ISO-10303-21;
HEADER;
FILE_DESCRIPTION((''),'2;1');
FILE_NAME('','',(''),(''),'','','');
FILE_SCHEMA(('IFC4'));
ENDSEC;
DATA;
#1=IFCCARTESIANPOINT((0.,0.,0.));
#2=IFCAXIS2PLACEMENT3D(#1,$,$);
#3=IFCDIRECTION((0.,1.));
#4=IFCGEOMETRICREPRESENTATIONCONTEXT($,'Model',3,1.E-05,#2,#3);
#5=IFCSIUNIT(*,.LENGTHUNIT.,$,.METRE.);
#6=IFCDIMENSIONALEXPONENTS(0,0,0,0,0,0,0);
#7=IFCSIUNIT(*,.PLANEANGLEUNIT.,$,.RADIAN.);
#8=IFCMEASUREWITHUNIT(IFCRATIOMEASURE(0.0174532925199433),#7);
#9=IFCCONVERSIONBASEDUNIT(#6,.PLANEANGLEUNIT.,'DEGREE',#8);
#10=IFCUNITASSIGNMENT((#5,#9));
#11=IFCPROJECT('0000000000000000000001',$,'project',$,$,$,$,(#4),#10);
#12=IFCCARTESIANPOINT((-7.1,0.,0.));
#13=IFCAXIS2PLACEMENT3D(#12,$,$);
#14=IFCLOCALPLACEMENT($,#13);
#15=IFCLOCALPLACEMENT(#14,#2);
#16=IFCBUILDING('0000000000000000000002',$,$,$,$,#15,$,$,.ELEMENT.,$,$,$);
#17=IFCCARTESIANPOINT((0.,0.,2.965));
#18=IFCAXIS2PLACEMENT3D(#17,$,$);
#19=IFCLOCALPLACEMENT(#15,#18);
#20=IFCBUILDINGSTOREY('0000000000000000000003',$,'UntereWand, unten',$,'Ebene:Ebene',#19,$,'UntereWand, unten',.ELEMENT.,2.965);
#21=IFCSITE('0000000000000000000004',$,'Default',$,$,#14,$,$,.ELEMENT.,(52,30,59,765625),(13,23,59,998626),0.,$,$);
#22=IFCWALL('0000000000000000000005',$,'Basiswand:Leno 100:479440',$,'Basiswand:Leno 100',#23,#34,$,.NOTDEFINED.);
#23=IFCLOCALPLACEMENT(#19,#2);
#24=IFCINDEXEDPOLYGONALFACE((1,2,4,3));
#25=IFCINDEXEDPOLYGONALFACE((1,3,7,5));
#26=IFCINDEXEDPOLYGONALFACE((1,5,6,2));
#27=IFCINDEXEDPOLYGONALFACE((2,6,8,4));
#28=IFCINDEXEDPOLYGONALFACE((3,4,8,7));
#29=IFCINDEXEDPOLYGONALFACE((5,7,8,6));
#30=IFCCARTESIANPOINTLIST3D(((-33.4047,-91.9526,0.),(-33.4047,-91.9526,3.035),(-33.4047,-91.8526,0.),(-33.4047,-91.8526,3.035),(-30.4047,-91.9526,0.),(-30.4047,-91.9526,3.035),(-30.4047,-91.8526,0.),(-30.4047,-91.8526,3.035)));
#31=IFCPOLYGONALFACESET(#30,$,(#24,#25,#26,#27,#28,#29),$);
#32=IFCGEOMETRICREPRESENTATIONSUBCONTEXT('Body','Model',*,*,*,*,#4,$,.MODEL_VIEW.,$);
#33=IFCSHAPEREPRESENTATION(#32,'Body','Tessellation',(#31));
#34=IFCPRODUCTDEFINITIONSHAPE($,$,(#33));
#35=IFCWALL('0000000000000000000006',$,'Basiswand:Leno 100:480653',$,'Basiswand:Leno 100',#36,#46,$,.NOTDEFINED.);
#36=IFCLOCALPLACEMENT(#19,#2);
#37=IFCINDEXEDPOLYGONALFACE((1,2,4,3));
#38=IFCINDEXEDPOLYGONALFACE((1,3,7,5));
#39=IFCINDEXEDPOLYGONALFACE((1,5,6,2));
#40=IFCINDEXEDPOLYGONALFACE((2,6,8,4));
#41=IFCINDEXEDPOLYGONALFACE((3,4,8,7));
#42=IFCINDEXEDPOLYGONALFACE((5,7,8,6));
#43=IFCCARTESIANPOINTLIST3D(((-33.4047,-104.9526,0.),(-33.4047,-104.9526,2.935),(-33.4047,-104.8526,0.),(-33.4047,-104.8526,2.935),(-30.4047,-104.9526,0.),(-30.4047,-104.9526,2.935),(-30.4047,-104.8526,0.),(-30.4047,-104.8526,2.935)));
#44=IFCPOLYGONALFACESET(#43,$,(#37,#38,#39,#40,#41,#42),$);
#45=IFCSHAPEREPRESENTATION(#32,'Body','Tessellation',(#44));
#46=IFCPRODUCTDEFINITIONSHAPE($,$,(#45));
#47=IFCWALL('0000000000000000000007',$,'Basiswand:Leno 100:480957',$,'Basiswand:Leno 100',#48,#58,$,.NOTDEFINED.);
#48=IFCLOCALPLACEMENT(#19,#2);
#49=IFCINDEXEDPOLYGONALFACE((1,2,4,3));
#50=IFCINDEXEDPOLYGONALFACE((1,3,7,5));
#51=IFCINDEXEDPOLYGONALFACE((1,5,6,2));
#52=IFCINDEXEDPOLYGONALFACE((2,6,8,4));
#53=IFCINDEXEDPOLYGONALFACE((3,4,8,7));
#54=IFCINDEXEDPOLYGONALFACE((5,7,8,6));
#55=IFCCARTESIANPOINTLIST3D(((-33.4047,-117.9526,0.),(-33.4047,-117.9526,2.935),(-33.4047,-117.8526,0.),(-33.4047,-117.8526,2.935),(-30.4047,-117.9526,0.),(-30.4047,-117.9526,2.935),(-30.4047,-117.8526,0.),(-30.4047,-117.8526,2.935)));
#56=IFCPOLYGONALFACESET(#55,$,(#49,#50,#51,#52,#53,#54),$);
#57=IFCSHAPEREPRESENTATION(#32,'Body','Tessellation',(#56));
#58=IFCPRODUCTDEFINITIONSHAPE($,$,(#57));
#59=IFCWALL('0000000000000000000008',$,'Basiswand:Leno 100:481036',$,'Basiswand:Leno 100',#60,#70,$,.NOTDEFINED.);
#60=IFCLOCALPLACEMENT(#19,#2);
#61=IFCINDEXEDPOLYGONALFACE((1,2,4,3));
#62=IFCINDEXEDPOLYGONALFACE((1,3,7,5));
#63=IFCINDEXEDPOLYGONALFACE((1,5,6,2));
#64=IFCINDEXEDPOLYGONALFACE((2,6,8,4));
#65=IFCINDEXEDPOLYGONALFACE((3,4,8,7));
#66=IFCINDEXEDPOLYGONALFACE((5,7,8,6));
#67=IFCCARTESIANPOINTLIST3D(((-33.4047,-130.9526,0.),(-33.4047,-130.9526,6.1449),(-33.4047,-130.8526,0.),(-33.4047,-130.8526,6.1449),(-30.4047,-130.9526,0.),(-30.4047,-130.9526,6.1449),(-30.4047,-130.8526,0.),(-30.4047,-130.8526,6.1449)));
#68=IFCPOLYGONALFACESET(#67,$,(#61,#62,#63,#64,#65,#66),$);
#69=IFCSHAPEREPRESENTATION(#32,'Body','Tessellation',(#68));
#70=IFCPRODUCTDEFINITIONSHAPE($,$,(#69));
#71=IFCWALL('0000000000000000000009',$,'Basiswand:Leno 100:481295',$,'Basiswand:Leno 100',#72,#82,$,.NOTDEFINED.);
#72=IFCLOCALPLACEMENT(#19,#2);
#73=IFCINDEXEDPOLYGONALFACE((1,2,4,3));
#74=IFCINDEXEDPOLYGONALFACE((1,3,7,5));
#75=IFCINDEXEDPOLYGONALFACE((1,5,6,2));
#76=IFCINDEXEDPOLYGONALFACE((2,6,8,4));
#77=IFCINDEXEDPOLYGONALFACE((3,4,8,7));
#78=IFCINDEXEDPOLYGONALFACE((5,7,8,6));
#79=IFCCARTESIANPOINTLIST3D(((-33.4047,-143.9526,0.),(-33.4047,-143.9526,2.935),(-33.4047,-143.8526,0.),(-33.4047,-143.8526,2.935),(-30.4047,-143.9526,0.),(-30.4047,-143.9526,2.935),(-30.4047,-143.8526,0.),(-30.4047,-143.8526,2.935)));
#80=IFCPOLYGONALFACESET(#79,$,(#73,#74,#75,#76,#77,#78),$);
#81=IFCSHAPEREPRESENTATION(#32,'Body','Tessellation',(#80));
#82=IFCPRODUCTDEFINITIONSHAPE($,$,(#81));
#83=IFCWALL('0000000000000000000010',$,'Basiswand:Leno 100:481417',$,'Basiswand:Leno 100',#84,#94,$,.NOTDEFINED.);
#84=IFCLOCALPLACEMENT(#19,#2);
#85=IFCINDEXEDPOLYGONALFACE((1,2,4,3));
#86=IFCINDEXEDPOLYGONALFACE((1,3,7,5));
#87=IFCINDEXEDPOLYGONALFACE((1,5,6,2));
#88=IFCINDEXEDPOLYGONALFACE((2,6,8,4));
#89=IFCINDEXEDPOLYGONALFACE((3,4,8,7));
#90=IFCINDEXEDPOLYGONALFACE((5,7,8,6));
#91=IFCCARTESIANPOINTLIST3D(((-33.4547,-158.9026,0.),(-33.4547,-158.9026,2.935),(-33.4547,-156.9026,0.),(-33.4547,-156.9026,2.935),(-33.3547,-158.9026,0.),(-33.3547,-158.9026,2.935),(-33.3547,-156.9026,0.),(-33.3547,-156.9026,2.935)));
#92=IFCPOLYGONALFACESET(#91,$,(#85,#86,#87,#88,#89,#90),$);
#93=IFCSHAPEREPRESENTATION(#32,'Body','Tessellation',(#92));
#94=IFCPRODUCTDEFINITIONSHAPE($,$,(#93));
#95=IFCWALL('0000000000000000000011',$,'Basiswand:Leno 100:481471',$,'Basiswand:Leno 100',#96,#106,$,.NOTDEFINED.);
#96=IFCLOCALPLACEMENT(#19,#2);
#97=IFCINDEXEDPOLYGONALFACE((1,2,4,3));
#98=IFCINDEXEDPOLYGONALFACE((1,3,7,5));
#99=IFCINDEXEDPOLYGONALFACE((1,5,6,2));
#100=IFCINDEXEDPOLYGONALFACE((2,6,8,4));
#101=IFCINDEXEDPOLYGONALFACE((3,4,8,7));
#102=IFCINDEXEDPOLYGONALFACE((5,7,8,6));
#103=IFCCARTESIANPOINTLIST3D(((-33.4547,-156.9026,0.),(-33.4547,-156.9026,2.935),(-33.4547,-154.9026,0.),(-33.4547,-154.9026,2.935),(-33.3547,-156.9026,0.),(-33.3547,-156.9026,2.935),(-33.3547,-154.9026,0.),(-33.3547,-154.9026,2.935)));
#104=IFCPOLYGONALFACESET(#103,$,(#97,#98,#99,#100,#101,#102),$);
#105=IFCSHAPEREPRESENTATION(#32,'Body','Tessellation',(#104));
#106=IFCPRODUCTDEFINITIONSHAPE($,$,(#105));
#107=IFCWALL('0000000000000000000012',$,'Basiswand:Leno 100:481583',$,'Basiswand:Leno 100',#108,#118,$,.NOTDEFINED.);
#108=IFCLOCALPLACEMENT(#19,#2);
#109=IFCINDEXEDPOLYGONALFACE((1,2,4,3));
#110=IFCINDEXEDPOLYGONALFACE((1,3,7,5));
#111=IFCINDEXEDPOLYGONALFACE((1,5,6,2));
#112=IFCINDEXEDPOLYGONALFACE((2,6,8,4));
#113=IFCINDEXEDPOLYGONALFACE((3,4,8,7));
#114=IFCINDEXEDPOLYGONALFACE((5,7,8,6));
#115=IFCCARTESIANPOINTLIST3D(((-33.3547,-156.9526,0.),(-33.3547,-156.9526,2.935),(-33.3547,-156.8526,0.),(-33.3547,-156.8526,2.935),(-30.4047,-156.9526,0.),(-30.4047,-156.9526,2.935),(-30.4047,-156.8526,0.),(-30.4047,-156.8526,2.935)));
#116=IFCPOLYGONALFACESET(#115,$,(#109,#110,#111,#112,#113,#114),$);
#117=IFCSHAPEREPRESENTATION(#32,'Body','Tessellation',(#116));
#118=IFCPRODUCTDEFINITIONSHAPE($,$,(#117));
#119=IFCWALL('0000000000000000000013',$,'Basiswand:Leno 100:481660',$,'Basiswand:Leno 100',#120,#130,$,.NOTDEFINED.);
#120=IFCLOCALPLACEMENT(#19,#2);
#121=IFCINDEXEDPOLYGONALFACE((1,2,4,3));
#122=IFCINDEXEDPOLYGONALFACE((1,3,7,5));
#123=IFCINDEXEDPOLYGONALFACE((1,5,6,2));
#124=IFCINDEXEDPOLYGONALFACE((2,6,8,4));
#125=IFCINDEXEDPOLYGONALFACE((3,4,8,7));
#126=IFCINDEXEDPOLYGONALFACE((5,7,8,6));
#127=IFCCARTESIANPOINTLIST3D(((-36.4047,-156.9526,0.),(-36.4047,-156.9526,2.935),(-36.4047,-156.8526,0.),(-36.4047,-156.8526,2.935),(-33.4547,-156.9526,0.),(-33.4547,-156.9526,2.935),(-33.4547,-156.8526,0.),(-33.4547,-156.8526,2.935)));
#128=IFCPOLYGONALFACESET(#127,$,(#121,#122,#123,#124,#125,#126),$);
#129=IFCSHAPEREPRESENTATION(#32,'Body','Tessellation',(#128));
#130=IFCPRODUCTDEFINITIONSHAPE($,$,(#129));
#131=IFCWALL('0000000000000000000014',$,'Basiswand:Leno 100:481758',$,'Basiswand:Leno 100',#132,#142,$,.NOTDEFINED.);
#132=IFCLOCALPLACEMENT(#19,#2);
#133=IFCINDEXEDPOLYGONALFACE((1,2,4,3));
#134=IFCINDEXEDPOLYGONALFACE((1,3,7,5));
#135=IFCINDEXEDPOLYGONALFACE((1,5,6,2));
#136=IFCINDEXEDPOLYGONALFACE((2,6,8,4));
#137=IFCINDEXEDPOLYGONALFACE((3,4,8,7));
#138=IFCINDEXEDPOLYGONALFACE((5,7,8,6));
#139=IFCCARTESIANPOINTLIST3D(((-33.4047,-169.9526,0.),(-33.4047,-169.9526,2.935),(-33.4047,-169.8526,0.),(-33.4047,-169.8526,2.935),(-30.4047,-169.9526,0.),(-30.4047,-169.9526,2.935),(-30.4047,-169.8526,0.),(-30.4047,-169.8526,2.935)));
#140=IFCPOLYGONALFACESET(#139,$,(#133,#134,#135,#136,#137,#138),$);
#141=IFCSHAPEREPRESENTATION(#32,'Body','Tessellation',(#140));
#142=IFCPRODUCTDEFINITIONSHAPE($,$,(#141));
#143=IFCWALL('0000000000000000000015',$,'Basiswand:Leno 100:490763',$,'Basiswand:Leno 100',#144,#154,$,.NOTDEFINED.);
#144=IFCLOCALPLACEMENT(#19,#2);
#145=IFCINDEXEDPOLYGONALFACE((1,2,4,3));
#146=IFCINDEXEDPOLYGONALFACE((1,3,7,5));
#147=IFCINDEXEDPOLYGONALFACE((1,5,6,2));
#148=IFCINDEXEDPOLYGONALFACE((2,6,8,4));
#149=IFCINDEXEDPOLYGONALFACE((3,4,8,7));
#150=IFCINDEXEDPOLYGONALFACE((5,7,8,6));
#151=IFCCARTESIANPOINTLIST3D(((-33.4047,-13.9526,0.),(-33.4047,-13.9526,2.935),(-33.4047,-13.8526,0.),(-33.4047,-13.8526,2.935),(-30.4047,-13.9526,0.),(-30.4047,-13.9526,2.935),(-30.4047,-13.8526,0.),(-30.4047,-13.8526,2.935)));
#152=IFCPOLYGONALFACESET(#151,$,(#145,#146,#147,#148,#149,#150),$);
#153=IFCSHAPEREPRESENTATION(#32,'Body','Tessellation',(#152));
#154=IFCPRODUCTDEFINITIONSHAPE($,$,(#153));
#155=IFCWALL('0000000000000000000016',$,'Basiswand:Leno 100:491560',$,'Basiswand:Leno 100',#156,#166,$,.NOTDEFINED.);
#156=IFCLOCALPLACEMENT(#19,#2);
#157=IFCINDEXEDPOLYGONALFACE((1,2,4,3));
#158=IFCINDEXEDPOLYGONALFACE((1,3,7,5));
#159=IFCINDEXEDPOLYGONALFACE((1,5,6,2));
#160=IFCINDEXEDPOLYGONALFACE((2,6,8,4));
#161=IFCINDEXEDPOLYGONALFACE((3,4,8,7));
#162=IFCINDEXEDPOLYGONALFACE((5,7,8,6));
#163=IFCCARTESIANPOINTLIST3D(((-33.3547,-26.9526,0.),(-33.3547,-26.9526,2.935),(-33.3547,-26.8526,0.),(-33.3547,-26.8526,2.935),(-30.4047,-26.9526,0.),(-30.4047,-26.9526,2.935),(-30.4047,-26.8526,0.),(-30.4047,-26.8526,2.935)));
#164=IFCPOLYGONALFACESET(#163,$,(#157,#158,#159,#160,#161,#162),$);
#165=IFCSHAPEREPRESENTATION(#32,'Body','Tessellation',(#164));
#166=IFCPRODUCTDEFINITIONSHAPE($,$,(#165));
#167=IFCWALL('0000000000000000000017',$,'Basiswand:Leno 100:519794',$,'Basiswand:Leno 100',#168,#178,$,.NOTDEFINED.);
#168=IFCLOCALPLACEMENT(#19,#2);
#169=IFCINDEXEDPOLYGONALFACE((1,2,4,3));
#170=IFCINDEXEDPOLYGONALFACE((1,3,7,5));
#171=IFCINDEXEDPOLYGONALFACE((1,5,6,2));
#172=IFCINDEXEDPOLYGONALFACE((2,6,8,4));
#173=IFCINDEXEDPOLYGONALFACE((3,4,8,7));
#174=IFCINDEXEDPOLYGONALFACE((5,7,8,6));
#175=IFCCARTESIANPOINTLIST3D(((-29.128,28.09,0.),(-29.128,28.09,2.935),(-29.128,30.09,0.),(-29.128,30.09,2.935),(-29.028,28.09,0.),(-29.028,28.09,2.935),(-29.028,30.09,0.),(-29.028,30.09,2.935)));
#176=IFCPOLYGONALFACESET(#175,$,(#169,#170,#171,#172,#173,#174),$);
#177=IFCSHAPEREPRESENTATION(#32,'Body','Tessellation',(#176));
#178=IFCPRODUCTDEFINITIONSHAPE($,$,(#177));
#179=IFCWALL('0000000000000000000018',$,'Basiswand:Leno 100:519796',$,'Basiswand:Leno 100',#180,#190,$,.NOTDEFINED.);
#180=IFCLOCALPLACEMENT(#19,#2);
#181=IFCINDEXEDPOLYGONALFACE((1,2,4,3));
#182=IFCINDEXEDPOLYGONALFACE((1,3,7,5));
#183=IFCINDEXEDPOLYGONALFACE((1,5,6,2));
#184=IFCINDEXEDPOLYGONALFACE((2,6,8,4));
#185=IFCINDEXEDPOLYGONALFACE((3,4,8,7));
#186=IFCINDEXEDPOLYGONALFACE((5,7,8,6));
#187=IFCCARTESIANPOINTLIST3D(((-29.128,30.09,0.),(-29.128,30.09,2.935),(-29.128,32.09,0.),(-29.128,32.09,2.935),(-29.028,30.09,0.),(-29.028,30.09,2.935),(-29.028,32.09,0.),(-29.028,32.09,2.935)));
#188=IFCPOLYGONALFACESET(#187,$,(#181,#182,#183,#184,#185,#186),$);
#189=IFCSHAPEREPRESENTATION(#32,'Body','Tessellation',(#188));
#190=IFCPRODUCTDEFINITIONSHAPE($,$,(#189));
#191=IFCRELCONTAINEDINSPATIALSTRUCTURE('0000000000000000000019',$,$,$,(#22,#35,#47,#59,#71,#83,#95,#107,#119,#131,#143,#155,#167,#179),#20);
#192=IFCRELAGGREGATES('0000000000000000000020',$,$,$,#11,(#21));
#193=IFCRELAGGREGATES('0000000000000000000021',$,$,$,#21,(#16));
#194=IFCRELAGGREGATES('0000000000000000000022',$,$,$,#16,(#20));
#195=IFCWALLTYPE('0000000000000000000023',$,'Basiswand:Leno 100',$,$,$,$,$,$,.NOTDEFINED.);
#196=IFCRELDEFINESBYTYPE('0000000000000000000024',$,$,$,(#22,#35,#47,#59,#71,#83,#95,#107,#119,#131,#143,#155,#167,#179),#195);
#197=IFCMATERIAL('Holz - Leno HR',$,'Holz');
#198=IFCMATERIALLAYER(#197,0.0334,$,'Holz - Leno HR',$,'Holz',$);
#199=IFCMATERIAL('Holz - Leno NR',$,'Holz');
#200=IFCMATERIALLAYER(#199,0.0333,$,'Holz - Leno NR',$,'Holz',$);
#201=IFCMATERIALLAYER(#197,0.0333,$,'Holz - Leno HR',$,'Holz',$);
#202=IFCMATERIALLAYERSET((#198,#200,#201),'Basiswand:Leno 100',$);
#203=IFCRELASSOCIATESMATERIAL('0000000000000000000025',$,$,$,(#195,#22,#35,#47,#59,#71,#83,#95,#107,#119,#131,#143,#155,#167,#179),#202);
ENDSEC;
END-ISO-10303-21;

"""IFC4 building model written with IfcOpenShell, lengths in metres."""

from ifc_helpers import new_model, entity, si_unit, converted_unit, direction, frame, origin, place, context, subcontext, project, spatial, indexed_curve, outline, extrude, material, layer, layer_set, type_object, element, save


model = new_model("IFC4")

# Units and contexts
model_context = context("Model", 3, precision=1e-05, world=origin(), true_north=direction((0.0, 1.0)))
body_context = subcontext(model_context, "Body", "Model", "MODEL_VIEW")
ifc_project = project(units=[si_unit("LENGTHUNIT", "METRE"), converted_unit("PLANEANGLEUNIT", "DEGREE", entity("IfcRatioMeasure", 0.0174532925199433), si_unit("PLANEANGLEUNIT", "RADIAN"), dimensions=[0, 0, 0, 0, 0, 0, 0])], contexts=[model_context])

# Site, building, storey
site_placement = place(None, frame((-7.1, 0.0, 0.0)))
site = spatial("IfcSite", under=ifc_project, at=site_placement, Name="Default", CompositionType="ELEMENT", RefLatitude=(52, 30, 59, 765625), RefLongitude=(13, 23, 59, 998626), RefElevation=0.0)
building_placement = place(site_placement, origin())
building = spatial("IfcBuilding", under=site, at=building_placement, CompositionType="ELEMENT")
storey_placement = place(building_placement, frame((0.0, 0.0, 2.965)))
storey = spatial("IfcBuildingStorey", under=building, at=storey_placement, Name="UntereWand, unten", ObjectType="Ebene:Ebene", LongName="UntereWand, unten", CompositionType="ELEMENT", Elevation=2.965)

# Walls
ifc_material_1 = material(Name="Holz - Leno HR", Category="Holz")
ifc_layer_1 = layer(ifc_material_1, 0.0334, Name="Holz - Leno HR", Category="Holz")
ifc_material_2 = material(Name="Holz - Leno NR", Category="Holz")
ifc_layer_2 = layer(ifc_material_2, 0.0333, Name="Holz - Leno NR", Category="Holz")
ifc_layer_3 = layer(ifc_material_1, 0.0333, Name="Holz - Leno HR", Category="Holz")
ifc_layer_set = layer_set([ifc_layer_1, ifc_layer_2, ifc_layer_3], Name="Basiswand:Leno 100")
wall_type = type_object("IfcWallType", Name="Basiswand:Leno 100", PredefinedType="NOTDEFINED", material=ifc_layer_set)
wall_1_placement = place(storey_placement, frame((-30.4047, -91.9026, 0.0), z_axis=(0.0, 0.0, 1.0), x_axis=(-1.0, 0.0, 0.0)))
element("IfcWall", 1, at=wall_1_placement, inside=storey, type_object=wall_type, material=ifc_layer_set, Name="Basiswand:Leno 100:479440", ObjectType="Basiswand:Leno 100", PredefinedType="NOTDEFINED", context=body_context, shape_type="SweptSolid", body=[
    extrude(outline(indexed_curve([(3.0, 0.05), (0.0, 0.05), (0.0, -0.05), (3.0, -0.05), (3.0, 0.05)], self_intersect=False)), origin(), (0.0, 0.0, 1.0), 3.035),
])
for number, where, z_axis, x_axis, name in (
    (2, (-30.4047, -104.9026, 0.0), (0.0, 0.0, 1.0), (-1.0, 0.0, 0.0), "Basiswand:Leno 100:480653"),
    (3, (-30.4047, -117.9026, 0.0), (0.0, 0.0, 1.0), (-1.0, 0.0, 0.0), "Basiswand:Leno 100:480957"),
):
    element("IfcWall", number, at=place(storey_placement, frame(where, z_axis=z_axis, x_axis=x_axis)), inside=storey, type_object=wall_type, material=ifc_layer_set, Name=name, ObjectType="Basiswand:Leno 100", PredefinedType="NOTDEFINED", context=body_context, shape_type="SweptSolid", body=[
        extrude(outline(indexed_curve([(3.0, 0.05), (0.0, 0.05), (0.0, -0.05), (3.0, -0.05), (3.0, 0.05)], self_intersect=False)), origin(), (0.0, 0.0, 1.0), 2.935),
    ])
wall_2_placement = place(storey_placement, frame((-30.4047, -130.9026, 0.0), z_axis=(0.0, 0.0, 1.0), x_axis=(-1.0, 0.0, 0.0)))
element("IfcWall", 4, at=wall_2_placement, inside=storey, type_object=wall_type, material=ifc_layer_set, Name="Basiswand:Leno 100:481036", ObjectType="Basiswand:Leno 100", PredefinedType="NOTDEFINED", context=body_context, shape_type="SweptSolid", body=[
    extrude(outline(indexed_curve([(3.0, 0.05), (0.0, 0.05), (0.0, -0.05), (3.0, -0.05), (3.0, 0.05)], self_intersect=False)), origin(), (0.0, 0.0, 1.0), 6.1449),
])
wall_3_placement = place(storey_placement, frame((-30.4047, -143.9026, 0.0), z_axis=(0.0, 0.0, 1.0), x_axis=(-1.0, 0.0, 0.0)))
element("IfcWall", 5, at=wall_3_placement, inside=storey, type_object=wall_type, material=ifc_layer_set, Name="Basiswand:Leno 100:481295", ObjectType="Basiswand:Leno 100", PredefinedType="NOTDEFINED", context=body_context, shape_type="SweptSolid", body=[
    extrude(outline(indexed_curve([(3.0, 0.05), (0.0, 0.05), (0.0, -0.05), (3.0, -0.05), (3.0, 0.05)], self_intersect=False)), origin(), (0.0, 0.0, 1.0), 2.935),
])
wall_4_placement = place(storey_placement, frame((-33.4047, -158.9026, 0.0), z_axis=(0.0, 0.0, 1.0), x_axis=(0.0, 1.0, 0.0)))
element("IfcWall", 6, at=wall_4_placement, inside=storey, type_object=wall_type, material=ifc_layer_set, Name="Basiswand:Leno 100:481417", ObjectType="Basiswand:Leno 100", PredefinedType="NOTDEFINED", context=body_context, shape_type="SweptSolid", body=[
    extrude(outline(indexed_curve([(2.0, 0.05), (0.0, 0.05), (0.0, -0.05), (2.0, -0.05), (2.0, 0.05)], self_intersect=False)), origin(), (0.0, 0.0, 1.0), 2.935),
])
wall_5_placement = place(storey_placement, frame((-33.4047, -154.9026, 0.0), z_axis=(0.0, 0.0, 1.0), x_axis=(0.0, -1.0, 0.0)))
element("IfcWall", 7, at=wall_5_placement, inside=storey, type_object=wall_type, material=ifc_layer_set, Name="Basiswand:Leno 100:481471", ObjectType="Basiswand:Leno 100", PredefinedType="NOTDEFINED", context=body_context, shape_type="SweptSolid", body=[
    extrude(outline(indexed_curve([(2.0, 0.05), (0.0, 0.05), (0.0, -0.05), (2.0, -0.05), (2.0, 0.05)], self_intersect=False)), origin(), (0.0, 0.0, 1.0), 2.935),
])
wall_6_placement = place(storey_placement, frame((-30.4047, -156.9026, 0.0), z_axis=(0.0, 0.0, 1.0), x_axis=(-1.0, 0.0, 0.0)))
element("IfcWall", 8, at=wall_6_placement, inside=storey, type_object=wall_type, material=ifc_layer_set, Name="Basiswand:Leno 100:481583", ObjectType="Basiswand:Leno 100", PredefinedType="NOTDEFINED", context=body_context, shape_type="SweptSolid", body=[
    extrude(outline(indexed_curve([(2.95, 0.05), (0.0, 0.05), (0.0, -0.05), (2.95, -0.05), (2.95, 0.05)], self_intersect=False)), origin(), (0.0, 0.0, 1.0), 2.935),
])
wall_7_placement = place(storey_placement, frame((-36.4047, -156.9026, 0.0)))
element("IfcWall", 9, at=wall_7_placement, inside=storey, type_object=wall_type, material=ifc_layer_set, Name="Basiswand:Leno 100:481660", ObjectType="Basiswand:Leno 100", PredefinedType="NOTDEFINED", context=body_context, shape_type="SweptSolid", body=[
    extrude(outline(indexed_curve([(2.95, 0.05), (0.0, 0.05), (0.0, -0.05), (2.95, -0.05), (2.95, 0.05)], self_intersect=False)), origin(), (0.0, 0.0, 1.0), 2.935),
])
wall_8_placement = place(storey_placement, frame((-30.4047, -169.9026, 0.0), z_axis=(0.0, 0.0, 1.0), x_axis=(-1.0, 0.0, 0.0)))
element("IfcWall", 10, at=wall_8_placement, inside=storey, type_object=wall_type, material=ifc_layer_set, Name="Basiswand:Leno 100:481758", ObjectType="Basiswand:Leno 100", PredefinedType="NOTDEFINED", context=body_context, shape_type="SweptSolid", body=[
    extrude(outline(indexed_curve([(3.0, 0.05), (0.0, 0.05), (0.0, -0.05), (3.0, -0.05), (3.0, 0.05)], self_intersect=False)), origin(), (0.0, 0.0, 1.0), 2.935),
])
wall_9_placement = place(storey_placement, frame((-33.4047, -13.9026, 0.0)))
element("IfcWall", 11, at=wall_9_placement, inside=storey, type_object=wall_type, material=ifc_layer_set, Name="Basiswand:Leno 100:490763", ObjectType="Basiswand:Leno 100", PredefinedType="NOTDEFINED", context=body_context, shape_type="SweptSolid", body=[
    extrude(outline(indexed_curve([(3.0, 0.05), (0.0, 0.05), (0.0, -0.05), (3.0, -0.05), (3.0, 0.05)], self_intersect=False)), origin(), (0.0, 0.0, 1.0), 2.935),
])
wall_10_placement = place(storey_placement, frame((-30.4047, -26.9026, 0.0), z_axis=(0.0, 0.0, 1.0), x_axis=(-1.0, 0.0, 0.0)))
element("IfcWall", 12, at=wall_10_placement, inside=storey, type_object=wall_type, material=ifc_layer_set, Name="Basiswand:Leno 100:491560", ObjectType="Basiswand:Leno 100", PredefinedType="NOTDEFINED", context=body_context, shape_type="SweptSolid", body=[
    extrude(outline(indexed_curve([(2.95, 0.05), (0.0, 0.05), (0.0, -0.05), (2.95, -0.05), (2.95, 0.05)], self_intersect=False)), origin(), (0.0, 0.0, 1.0), 2.935),
])
wall_11_placement = place(storey_placement, frame((-29.078, 28.09, 0.0), z_axis=(0.0, 0.0, 1.0), x_axis=(0.0, 1.0, 0.0)))
element("IfcWall", 13, at=wall_11_placement, inside=storey, type_object=wall_type, material=ifc_layer_set, Name="Basiswand:Leno 100:519794", ObjectType="Basiswand:Leno 100", PredefinedType="NOTDEFINED", context=body_context, shape_type="SweptSolid", body=[
    extrude(outline(indexed_curve([(2.0, 0.05), (0.0, 0.05), (0.0, -0.05), (2.0, -0.05), (2.0, 0.05)], self_intersect=False)), origin(), (0.0, 0.0, 1.0), 2.935),
])
wall_12_placement = place(storey_placement, frame((-29.078, 32.09, 0.0), z_axis=(0.0, 0.0, 1.0), x_axis=(0.0, -1.0, 0.0)))
element("IfcWall", 14, at=wall_12_placement, inside=storey, type_object=wall_type, material=ifc_layer_set, Name="Basiswand:Leno 100:519796", ObjectType="Basiswand:Leno 100", PredefinedType="NOTDEFINED", context=body_context, shape_type="SweptSolid", body=[
    extrude(outline(indexed_curve([(2.0, 0.05), (0.0, 0.05), (0.0, -0.05), (2.0, -0.05), (2.0, 0.05)], self_intersect=False)), origin(), (0.0, 0.0, 1.0), 2.935),
])

save(model, "model.ifc")
